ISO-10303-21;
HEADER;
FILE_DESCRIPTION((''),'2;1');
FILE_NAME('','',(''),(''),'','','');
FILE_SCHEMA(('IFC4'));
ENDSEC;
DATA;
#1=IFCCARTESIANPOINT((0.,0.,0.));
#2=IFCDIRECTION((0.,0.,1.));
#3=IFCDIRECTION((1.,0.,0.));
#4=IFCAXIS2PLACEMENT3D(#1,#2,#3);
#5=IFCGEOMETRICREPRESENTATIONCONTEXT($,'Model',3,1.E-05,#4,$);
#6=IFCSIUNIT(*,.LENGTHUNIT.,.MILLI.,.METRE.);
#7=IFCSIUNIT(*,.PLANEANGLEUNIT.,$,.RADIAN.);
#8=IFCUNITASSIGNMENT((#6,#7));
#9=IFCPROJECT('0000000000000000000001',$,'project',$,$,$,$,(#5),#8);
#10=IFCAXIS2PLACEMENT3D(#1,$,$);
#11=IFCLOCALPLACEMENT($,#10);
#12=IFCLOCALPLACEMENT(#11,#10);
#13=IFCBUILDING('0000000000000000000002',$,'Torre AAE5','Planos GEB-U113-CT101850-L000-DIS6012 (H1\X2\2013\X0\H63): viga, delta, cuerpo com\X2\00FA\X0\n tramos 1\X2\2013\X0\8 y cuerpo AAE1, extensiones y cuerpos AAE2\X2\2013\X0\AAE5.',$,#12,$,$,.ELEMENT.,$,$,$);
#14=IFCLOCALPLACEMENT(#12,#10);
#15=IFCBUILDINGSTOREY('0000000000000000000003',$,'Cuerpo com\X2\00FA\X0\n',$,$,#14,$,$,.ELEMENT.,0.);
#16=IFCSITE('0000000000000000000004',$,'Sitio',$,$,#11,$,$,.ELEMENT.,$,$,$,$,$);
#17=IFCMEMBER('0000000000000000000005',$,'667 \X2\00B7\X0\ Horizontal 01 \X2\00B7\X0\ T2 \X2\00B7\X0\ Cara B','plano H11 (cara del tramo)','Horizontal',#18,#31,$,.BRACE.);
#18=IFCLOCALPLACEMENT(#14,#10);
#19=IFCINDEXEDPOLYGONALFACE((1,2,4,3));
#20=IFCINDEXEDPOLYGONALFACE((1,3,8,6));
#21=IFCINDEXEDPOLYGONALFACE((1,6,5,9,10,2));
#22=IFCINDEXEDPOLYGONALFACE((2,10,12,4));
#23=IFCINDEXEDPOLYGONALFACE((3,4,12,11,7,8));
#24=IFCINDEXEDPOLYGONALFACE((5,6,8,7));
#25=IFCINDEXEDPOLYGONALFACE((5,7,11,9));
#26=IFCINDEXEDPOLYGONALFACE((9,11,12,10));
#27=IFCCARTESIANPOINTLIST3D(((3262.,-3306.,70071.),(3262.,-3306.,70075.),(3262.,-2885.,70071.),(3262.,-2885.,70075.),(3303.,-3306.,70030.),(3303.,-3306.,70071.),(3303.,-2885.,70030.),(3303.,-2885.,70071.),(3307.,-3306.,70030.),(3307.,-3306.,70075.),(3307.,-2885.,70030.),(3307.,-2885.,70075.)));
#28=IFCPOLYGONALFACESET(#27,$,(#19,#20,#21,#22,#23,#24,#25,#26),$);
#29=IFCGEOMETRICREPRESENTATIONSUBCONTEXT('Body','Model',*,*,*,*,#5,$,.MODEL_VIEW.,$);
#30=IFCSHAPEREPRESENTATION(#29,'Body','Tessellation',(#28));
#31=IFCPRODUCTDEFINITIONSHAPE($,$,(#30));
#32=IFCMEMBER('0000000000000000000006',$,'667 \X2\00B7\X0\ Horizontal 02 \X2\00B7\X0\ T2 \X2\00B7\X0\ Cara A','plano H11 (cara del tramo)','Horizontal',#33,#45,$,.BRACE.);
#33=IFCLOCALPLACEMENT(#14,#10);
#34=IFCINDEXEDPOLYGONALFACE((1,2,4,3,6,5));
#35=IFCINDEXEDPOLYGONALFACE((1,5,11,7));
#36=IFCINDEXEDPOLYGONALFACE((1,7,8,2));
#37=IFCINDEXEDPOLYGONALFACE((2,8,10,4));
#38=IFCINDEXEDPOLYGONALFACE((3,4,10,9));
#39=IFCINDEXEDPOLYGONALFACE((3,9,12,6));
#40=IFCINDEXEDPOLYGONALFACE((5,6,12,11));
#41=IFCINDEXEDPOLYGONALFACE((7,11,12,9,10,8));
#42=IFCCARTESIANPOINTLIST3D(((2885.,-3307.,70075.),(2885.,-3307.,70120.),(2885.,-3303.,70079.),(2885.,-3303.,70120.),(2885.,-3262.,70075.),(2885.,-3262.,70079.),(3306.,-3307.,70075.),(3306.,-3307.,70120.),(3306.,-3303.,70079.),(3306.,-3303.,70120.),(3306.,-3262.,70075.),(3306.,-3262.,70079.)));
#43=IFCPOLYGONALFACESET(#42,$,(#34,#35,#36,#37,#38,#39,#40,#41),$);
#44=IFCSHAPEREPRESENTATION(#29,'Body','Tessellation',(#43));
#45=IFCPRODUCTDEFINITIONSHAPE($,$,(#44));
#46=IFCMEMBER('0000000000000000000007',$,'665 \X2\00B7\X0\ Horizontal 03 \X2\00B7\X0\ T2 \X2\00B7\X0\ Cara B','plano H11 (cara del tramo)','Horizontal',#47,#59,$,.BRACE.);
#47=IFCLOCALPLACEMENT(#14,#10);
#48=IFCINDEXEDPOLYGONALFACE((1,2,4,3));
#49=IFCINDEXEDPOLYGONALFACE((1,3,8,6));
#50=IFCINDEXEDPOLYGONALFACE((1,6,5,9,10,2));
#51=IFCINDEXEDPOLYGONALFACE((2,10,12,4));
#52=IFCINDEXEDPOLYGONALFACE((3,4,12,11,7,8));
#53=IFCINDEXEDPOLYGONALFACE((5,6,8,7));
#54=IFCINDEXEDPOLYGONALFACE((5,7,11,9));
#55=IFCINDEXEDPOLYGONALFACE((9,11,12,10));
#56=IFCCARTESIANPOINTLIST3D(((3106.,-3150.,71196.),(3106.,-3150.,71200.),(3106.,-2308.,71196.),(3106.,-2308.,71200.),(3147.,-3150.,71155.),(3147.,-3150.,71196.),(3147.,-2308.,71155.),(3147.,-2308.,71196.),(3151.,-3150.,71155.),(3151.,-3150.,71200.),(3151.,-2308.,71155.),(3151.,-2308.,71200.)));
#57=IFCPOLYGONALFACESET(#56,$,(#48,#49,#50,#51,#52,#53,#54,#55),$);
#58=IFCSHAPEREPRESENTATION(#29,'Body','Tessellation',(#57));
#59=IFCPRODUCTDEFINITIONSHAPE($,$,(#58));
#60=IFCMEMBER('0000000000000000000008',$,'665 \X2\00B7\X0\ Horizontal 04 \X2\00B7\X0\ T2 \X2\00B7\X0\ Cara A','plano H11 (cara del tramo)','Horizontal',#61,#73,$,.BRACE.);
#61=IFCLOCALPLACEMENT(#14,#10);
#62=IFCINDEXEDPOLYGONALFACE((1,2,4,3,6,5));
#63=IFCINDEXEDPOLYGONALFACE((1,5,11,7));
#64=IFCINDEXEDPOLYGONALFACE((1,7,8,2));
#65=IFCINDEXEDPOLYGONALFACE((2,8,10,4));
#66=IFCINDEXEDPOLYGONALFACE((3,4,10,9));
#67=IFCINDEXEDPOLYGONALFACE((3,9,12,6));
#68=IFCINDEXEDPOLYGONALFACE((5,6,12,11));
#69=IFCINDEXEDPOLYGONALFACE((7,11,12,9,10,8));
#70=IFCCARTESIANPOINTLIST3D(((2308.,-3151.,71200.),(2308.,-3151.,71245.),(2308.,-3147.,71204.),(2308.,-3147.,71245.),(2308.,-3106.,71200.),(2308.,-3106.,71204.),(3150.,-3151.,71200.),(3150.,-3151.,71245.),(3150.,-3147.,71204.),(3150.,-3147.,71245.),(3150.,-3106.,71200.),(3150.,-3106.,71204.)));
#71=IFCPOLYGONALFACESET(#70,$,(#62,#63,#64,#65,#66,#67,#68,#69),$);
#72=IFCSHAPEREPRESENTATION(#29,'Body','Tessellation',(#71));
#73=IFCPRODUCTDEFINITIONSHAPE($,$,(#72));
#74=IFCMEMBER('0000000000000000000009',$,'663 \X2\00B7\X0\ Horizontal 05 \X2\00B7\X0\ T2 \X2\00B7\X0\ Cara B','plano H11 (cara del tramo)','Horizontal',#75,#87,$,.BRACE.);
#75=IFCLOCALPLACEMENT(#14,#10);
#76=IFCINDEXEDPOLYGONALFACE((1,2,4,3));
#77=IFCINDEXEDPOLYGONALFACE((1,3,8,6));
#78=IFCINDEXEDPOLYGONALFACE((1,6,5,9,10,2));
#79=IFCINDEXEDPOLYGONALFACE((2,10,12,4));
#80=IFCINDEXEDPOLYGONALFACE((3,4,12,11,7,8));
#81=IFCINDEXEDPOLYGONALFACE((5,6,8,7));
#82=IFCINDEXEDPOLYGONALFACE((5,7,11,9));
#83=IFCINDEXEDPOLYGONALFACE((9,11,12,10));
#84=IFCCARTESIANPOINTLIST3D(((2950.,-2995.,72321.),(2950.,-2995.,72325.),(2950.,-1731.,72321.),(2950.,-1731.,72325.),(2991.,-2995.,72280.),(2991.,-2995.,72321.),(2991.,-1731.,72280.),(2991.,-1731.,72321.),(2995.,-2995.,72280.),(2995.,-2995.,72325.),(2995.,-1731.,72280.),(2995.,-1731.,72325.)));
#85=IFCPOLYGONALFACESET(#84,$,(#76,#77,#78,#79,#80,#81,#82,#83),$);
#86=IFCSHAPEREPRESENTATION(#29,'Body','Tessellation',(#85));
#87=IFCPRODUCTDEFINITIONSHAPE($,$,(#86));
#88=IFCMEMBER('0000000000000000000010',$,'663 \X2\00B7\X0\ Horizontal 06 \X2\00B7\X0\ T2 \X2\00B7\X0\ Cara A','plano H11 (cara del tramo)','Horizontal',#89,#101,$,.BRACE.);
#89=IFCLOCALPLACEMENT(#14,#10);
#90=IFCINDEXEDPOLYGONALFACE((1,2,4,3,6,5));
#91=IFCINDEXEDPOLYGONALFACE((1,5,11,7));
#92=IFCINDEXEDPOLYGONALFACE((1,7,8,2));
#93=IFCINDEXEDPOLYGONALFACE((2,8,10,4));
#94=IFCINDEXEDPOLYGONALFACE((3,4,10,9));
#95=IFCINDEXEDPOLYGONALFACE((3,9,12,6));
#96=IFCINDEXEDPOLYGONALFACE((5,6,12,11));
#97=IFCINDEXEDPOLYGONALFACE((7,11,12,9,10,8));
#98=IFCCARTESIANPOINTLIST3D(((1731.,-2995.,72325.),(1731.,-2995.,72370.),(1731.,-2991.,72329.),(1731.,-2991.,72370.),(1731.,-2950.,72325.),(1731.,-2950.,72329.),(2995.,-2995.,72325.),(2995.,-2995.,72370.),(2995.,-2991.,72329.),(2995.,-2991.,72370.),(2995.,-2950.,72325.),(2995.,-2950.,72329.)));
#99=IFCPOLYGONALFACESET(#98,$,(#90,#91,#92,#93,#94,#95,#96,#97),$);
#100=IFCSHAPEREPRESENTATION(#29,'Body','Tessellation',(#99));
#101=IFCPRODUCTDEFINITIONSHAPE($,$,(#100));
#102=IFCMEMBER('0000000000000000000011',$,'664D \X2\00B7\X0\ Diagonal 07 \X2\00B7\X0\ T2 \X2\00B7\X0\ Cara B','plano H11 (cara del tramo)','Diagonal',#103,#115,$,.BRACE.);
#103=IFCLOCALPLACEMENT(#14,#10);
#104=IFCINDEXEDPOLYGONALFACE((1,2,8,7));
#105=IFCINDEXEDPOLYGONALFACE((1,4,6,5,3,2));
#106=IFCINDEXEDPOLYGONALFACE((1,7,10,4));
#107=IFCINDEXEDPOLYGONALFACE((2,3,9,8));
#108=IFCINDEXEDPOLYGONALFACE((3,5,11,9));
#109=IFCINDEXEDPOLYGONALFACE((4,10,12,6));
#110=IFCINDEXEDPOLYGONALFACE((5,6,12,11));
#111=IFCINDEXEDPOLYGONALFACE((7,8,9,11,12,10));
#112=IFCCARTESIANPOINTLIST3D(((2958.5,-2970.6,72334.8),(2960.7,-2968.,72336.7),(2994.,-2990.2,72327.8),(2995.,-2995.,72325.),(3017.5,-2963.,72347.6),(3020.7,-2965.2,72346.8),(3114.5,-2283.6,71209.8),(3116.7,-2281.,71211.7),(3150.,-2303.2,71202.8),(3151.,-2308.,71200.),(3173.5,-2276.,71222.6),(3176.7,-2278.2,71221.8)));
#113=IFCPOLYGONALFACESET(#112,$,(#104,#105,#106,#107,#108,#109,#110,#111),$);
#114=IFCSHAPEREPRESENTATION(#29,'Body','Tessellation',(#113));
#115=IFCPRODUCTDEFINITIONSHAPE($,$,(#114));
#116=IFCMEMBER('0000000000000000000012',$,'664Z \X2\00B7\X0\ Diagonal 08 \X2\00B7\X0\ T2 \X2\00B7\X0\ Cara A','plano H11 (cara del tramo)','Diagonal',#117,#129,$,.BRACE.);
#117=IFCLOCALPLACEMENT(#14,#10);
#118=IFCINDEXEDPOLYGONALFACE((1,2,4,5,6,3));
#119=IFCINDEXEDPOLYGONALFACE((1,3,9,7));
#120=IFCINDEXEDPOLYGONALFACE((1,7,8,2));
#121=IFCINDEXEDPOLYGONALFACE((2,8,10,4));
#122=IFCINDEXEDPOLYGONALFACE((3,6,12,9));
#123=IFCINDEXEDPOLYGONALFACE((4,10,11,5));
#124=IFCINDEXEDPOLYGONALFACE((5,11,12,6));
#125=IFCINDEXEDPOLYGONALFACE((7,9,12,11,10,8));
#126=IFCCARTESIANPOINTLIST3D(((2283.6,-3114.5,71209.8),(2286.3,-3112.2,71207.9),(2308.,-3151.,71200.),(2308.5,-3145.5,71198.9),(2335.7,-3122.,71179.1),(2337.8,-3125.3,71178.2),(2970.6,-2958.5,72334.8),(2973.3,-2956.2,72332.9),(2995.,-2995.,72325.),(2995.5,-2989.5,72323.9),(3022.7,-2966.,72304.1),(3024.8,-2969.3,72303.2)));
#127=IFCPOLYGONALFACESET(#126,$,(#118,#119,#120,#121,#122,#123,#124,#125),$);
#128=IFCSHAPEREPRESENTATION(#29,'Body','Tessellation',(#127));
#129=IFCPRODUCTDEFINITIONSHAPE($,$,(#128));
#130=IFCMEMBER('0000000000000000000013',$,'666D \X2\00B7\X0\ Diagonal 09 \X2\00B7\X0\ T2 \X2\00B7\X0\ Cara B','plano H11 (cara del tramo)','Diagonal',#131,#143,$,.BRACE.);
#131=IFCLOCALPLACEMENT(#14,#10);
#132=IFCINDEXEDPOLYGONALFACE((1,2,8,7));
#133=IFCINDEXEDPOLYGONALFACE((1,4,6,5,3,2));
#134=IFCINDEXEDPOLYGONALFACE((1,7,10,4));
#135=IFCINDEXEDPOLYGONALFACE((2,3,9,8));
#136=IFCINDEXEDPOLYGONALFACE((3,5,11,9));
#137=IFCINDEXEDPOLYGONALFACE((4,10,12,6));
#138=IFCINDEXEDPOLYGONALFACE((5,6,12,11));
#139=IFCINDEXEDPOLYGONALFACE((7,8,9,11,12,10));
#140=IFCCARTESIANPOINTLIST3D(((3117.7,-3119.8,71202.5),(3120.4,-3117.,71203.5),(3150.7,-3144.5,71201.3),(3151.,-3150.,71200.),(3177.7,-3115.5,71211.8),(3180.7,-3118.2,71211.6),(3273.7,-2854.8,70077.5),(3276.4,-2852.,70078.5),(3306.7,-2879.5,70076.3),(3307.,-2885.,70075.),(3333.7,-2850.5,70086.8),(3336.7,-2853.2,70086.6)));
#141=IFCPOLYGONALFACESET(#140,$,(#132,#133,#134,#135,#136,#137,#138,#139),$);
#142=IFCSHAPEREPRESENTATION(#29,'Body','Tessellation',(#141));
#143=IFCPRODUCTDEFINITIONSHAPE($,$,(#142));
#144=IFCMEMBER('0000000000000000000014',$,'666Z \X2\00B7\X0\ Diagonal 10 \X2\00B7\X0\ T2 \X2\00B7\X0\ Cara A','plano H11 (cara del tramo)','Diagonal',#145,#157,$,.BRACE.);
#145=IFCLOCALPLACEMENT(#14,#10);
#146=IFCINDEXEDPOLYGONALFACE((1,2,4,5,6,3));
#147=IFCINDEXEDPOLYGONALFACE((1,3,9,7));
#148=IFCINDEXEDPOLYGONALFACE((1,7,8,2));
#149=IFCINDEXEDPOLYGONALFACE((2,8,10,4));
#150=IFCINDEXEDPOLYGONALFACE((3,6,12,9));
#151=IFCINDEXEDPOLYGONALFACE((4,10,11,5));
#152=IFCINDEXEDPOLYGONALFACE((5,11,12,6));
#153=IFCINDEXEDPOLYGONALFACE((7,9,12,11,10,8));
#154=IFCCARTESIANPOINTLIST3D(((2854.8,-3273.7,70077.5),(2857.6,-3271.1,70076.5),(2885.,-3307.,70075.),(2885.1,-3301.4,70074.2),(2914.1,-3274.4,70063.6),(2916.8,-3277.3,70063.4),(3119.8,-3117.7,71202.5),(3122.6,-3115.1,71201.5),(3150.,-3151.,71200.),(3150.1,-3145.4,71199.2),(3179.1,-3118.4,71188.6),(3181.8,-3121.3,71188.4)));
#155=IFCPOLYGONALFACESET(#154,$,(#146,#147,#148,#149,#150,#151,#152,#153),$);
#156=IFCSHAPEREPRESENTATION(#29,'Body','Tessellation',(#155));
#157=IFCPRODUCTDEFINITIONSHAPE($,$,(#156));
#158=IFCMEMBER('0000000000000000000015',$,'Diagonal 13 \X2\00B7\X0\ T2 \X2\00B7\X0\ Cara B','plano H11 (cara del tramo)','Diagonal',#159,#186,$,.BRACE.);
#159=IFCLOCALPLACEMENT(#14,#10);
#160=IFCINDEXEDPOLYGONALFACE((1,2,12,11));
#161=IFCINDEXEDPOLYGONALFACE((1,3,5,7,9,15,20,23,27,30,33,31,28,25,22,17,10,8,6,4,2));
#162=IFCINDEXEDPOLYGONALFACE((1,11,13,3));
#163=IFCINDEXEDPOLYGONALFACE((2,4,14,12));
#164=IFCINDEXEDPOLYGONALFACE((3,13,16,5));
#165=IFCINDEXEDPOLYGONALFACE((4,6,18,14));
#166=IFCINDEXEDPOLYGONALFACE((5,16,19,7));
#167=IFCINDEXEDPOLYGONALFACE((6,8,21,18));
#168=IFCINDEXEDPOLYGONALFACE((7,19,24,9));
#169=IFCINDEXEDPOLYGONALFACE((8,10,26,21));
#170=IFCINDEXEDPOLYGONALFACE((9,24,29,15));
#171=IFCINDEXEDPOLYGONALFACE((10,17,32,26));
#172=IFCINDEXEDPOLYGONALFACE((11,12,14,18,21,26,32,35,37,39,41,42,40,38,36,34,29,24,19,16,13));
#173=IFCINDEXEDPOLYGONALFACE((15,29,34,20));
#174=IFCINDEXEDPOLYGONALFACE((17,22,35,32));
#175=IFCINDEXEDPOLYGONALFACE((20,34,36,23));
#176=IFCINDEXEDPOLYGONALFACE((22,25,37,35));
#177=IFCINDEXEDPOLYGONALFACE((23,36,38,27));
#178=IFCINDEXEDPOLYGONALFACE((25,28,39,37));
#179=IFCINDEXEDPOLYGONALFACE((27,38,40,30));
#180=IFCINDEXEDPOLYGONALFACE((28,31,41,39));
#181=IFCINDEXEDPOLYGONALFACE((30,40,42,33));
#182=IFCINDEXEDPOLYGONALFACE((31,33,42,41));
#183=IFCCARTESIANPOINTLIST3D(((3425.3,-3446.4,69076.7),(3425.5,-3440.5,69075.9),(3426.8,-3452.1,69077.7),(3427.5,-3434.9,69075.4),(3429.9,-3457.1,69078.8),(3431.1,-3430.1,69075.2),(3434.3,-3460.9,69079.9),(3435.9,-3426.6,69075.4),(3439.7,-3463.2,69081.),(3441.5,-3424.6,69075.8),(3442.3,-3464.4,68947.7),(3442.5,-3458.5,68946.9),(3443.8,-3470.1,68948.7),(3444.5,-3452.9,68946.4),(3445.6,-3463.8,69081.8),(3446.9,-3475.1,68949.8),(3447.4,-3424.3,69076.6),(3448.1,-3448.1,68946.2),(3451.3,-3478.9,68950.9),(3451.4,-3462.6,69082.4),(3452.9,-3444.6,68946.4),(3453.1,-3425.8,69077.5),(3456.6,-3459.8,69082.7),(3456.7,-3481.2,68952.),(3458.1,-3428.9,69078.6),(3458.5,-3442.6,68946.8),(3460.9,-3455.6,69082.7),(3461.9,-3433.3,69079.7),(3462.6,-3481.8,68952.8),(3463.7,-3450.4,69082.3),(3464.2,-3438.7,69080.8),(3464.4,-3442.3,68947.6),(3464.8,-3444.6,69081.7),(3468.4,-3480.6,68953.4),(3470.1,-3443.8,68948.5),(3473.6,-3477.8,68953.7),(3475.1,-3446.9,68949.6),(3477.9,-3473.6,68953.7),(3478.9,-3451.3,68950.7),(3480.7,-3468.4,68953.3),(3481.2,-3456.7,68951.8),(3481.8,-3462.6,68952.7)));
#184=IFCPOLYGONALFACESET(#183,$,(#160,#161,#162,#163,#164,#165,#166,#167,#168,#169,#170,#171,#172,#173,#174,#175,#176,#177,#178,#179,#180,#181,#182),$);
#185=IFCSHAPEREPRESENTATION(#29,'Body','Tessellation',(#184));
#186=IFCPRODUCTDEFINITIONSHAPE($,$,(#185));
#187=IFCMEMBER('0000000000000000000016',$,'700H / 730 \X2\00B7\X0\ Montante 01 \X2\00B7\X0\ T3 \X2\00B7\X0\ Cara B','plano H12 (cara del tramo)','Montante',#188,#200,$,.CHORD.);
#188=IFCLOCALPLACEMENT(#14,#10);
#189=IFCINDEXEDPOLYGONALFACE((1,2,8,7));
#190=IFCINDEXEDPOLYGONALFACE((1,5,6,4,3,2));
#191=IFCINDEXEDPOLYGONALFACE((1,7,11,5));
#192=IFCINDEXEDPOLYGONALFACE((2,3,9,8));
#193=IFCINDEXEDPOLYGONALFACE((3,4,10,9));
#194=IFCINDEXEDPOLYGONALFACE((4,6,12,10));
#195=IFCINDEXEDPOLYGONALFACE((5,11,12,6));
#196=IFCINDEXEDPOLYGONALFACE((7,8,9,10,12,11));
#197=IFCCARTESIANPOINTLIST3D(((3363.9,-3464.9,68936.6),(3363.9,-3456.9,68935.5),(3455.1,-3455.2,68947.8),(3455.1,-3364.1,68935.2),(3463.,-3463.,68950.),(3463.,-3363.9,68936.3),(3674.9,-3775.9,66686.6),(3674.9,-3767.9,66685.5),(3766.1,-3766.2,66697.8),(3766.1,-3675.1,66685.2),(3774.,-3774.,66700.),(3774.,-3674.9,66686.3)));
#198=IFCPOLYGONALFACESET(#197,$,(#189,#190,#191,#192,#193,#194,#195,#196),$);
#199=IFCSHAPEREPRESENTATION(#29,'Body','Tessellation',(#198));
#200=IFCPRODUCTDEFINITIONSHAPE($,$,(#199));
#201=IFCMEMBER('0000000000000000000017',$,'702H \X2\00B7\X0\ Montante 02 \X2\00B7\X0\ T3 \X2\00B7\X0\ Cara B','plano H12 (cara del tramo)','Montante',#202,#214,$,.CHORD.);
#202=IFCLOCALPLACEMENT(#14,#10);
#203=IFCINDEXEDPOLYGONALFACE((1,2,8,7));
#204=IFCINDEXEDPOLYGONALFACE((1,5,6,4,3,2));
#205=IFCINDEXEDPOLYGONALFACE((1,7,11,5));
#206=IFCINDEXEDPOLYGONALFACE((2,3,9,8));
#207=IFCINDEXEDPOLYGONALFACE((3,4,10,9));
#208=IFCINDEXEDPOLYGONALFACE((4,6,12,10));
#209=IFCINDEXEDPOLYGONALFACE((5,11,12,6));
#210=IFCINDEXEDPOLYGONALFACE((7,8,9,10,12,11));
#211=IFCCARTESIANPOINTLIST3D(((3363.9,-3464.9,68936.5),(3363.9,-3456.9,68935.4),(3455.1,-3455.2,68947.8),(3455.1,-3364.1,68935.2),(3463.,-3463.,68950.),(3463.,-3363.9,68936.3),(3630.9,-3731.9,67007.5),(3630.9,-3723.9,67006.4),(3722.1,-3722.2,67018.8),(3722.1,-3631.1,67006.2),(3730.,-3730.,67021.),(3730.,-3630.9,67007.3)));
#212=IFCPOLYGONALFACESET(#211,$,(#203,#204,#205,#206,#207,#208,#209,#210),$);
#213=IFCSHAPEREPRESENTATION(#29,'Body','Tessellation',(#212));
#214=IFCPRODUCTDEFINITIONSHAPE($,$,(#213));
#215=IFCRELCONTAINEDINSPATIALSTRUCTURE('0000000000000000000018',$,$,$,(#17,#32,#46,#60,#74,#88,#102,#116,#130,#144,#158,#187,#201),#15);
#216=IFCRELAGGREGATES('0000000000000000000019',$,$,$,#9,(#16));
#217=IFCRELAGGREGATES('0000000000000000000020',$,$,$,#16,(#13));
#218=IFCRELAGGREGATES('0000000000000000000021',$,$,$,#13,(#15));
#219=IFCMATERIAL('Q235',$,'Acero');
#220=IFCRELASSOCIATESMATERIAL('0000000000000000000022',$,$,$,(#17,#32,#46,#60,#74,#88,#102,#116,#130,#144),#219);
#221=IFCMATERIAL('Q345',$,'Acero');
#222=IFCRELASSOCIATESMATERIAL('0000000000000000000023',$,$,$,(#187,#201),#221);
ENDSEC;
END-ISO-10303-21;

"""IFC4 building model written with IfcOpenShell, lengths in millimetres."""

from ifc_helpers import new_model, si_unit, frame, frame_2d, origin, origin_with_axes, place, context, subcontext, project, spatial, circle, l_section, extrude, material, element, save


model = new_model("IFC4")

# Units and contexts
model_context = context("Model", 3, precision=1e-05, world=origin_with_axes())
body_context = subcontext(model_context, "Body", "Model", "MODEL_VIEW")
ifc_project = project(units=[si_unit("LENGTHUNIT", "METRE", prefix="MILLI"), si_unit("PLANEANGLEUNIT", "RADIAN")], contexts=[model_context])

# Site, building, storey
site_placement = place(None, origin())
site = spatial("IfcSite", under=ifc_project, at=site_placement, Name="Sitio", CompositionType="ELEMENT")
building_placement = place(site_placement, origin())
building = spatial("IfcBuilding", under=site, at=building_placement, Name="Torre AAE5", Description="Planos GEB-U113-CT101850-L000-DIS6012 (H1–H63): viga, delta, cuerpo común tramos 1–8 y cuerpo AAE1, extensiones y cuerpos AAE2–AAE5.", CompositionType="ELEMENT")
storey_placement = place(building_placement, origin())
storey = spatial("IfcBuildingStorey", under=building, at=storey_placement, Name="Cuerpo común", CompositionType="ELEMENT", Elevation=0.0)

# Members
ifc_material_1 = material(Name="Q235", Category="Acero")
for number, where, z_axis, x_axis, name in (
    (1, (3307.0, -2885.0, 70075.0), (0.0, -1.0, 0.0), (-1.0, 0.0, 0.0), "667 · Horizontal 01 · T2 · Cara B"),
    (2, (2885.0, -3307.0, 70075.0), (1.0, 0.0, 0.0), (0.0, 1.0, 0.0), "667 · Horizontal 02 · T2 · Cara A"),
):
    element("IfcMember", number, at=place(storey_placement, frame(where, z_axis=z_axis, x_axis=x_axis)), inside=storey, material=ifc_material_1, Name=name, Description="plano H11 (cara del tramo)", ObjectType="Horizontal", PredefinedType="BRACE", context=body_context, shape_type="SweptSolid", body=[
        extrude(l_section(Depth=45.0, Width=45.0, Thickness=4.0, at=frame_2d((22.5, 22.5))), None, (0.0, 0.0, 1.0), 421.0),
    ])
for number, where, z_axis, x_axis, name in (
    (3, (3151.0, -2308.0, 71200.0), (0.0, -1.0, 0.0), (-1.0, 0.0, 0.0), "665 · Horizontal 03 · T2 · Cara B"),
    (4, (2308.0, -3151.0, 71200.0), (1.0, 0.0, 0.0), (0.0, 1.0, 0.0), "665 · Horizontal 04 · T2 · Cara A"),
):
    element("IfcMember", number, at=place(storey_placement, frame(where, z_axis=z_axis, x_axis=x_axis)), inside=storey, material=ifc_material_1, Name=name, Description="plano H11 (cara del tramo)", ObjectType="Horizontal", PredefinedType="BRACE", context=body_context, shape_type="SweptSolid", body=[
        extrude(l_section(Depth=45.0, Width=45.0, Thickness=4.0, at=frame_2d((22.5, 22.5))), None, (0.0, 0.0, 1.0), 842.0),
    ])
for number, where, z_axis, x_axis, name in (
    (5, (2995.0, -1731.0, 72325.0), (0.0, -1.0, 0.0), (-1.0, 0.0, 0.0), "663 · Horizontal 05 · T2 · Cara B"),
    (6, (1731.0, -2995.0, 72325.0), (1.0, 0.0, 0.0), (0.0, 1.0, 0.0), "663 · Horizontal 06 · T2 · Cara A"),
):
    element("IfcMember", number, at=place(storey_placement, frame(where, z_axis=z_axis, x_axis=x_axis)), inside=storey, material=ifc_material_1, Name=name, Description="plano H11 (cara del tramo)", ObjectType="Horizontal", PredefinedType="BRACE", context=body_context, shape_type="SweptSolid", body=[
        extrude(l_section(Depth=45.0, Width=45.0, Thickness=4.0, at=frame_2d((22.5, 22.5))), None, (0.0, 0.0, 1.0), 1264.0),
    ])
for number, where, z_axis, x_axis, name in (
    (7, (2995.0, -2995.0, 72325.0), (0.117525, 0.517562, -0.847536), (-0.812003, 0.541404, 0.21802), "664D · Diagonal 07 · T2 · Cara B"),
    (8, (2995.0, -2995.0, 72325.0), (-0.517562, -0.117525, -0.847536), (-0.541404, 0.812003, 0.21802), "664Z · Diagonal 08 · T2 · Cara A"),
):
    element("IfcMember", number, at=place(storey_placement, frame(where, z_axis=z_axis, x_axis=x_axis)), inside=storey, material=ifc_material_1, Name=name, Description="plano H11 (cara del tramo)", ObjectType="Diagonal", PredefinedType="BRACE", context=body_context, shape_type="SweptSolid", body=[
        extrude(l_section(Depth=45.0, Width=45.0, Thickness=4.0, at=frame_2d((22.5, 22.5))), None, (0.0, 0.0, 1.0), 1327.4),
    ])
for number, where, z_axis, x_axis, name in (
    (9, (3151.0, -3150.0, 71200.0), (0.13376, 0.22722, -0.964614), (-0.739529, 0.670835, 0.055471), "666D · Diagonal 09 · T2 · Cara B"),
    (10, (3150.0, -3151.0, 71200.0), (-0.22722, -0.13376, -0.964614), (-0.670835, 0.739529, 0.055471), "666Z · Diagonal 10 · T2 · Cara A"),
):
    element("IfcMember", number, at=place(storey_placement, frame(where, z_axis=z_axis, x_axis=x_axis)), inside=storey, material=ifc_material_1, Name=name, Description="plano H11 (cara del tramo)", ObjectType="Diagonal", PredefinedType="BRACE", context=body_context, shape_type="SweptSolid", body=[
        extrude(l_section(Depth=45.0, Width=45.0, Thickness=4.0, at=frame_2d((22.5, 22.5))), None, (0.0, 0.0, 1.0), 1166.3),
    ])
member_1_placement = place(storey_placement, frame((3445.0, -3444.0, 69079.0), z_axis=(0.129421, -0.137034, -0.982075), x_axis=(-0.695225, 0.69366, -0.188409)))
element("IfcMember", 11, at=member_1_placement, inside=storey, Name="Diagonal 13 · T2 · Cara B", Description="plano H11 (cara del tramo)", ObjectType="Diagonal", PredefinedType="BRACE", context=body_context, shape_type="SweptSolid", body=[
    extrude(circle(Radius=20.0), None, (0.0, 0.0, 1.0), 131.4),
])
ifc_material_2 = material(Name="Q345", Category="Acero")
member_2_placement = place(storey_placement, frame((3463.0, -3463.0, 68950.0), z_axis=(0.135655, -0.135655, -0.981425), x_axis=(-0.990756, -0.018574, -0.134377)))
element("IfcMember", 12, at=member_2_placement, inside=storey, material=ifc_material_2, Name="700H / 730 · Montante 01 · T3 · Cara B", Description="plano H12 (cara del tramo)", ObjectType="Montante", PredefinedType="CHORD", context=body_context, shape_type="SweptSolid", body=[
    extrude(l_section(Depth=100.0, Width=100.0, Thickness=8.0, at=frame_2d((50.0, 50.0))), None, (0.0, 0.0, 1.0), 2292.6),
])
member_3_placement = place(storey_placement, frame((3463.0, -3463.0, 68950.0), z_axis=(0.135836, -0.135836, -0.981375), x_axis=(-0.990731, -0.018624, -0.134553)))
element("IfcMember", 13, at=member_3_placement, inside=storey, material=ifc_material_2, Name="702H · Montante 02 · T3 · Cara B", Description="plano H12 (cara del tramo)", ObjectType="Montante", PredefinedType="CHORD", context=body_context, shape_type="SweptSolid", body=[
    extrude(l_section(Depth=100.0, Width=100.0, Thickness=8.0, at=frame_2d((50.0, 50.0))), None, (0.0, 0.0, 1.0), 1965.6),
])

save(model, "model.ifc")
